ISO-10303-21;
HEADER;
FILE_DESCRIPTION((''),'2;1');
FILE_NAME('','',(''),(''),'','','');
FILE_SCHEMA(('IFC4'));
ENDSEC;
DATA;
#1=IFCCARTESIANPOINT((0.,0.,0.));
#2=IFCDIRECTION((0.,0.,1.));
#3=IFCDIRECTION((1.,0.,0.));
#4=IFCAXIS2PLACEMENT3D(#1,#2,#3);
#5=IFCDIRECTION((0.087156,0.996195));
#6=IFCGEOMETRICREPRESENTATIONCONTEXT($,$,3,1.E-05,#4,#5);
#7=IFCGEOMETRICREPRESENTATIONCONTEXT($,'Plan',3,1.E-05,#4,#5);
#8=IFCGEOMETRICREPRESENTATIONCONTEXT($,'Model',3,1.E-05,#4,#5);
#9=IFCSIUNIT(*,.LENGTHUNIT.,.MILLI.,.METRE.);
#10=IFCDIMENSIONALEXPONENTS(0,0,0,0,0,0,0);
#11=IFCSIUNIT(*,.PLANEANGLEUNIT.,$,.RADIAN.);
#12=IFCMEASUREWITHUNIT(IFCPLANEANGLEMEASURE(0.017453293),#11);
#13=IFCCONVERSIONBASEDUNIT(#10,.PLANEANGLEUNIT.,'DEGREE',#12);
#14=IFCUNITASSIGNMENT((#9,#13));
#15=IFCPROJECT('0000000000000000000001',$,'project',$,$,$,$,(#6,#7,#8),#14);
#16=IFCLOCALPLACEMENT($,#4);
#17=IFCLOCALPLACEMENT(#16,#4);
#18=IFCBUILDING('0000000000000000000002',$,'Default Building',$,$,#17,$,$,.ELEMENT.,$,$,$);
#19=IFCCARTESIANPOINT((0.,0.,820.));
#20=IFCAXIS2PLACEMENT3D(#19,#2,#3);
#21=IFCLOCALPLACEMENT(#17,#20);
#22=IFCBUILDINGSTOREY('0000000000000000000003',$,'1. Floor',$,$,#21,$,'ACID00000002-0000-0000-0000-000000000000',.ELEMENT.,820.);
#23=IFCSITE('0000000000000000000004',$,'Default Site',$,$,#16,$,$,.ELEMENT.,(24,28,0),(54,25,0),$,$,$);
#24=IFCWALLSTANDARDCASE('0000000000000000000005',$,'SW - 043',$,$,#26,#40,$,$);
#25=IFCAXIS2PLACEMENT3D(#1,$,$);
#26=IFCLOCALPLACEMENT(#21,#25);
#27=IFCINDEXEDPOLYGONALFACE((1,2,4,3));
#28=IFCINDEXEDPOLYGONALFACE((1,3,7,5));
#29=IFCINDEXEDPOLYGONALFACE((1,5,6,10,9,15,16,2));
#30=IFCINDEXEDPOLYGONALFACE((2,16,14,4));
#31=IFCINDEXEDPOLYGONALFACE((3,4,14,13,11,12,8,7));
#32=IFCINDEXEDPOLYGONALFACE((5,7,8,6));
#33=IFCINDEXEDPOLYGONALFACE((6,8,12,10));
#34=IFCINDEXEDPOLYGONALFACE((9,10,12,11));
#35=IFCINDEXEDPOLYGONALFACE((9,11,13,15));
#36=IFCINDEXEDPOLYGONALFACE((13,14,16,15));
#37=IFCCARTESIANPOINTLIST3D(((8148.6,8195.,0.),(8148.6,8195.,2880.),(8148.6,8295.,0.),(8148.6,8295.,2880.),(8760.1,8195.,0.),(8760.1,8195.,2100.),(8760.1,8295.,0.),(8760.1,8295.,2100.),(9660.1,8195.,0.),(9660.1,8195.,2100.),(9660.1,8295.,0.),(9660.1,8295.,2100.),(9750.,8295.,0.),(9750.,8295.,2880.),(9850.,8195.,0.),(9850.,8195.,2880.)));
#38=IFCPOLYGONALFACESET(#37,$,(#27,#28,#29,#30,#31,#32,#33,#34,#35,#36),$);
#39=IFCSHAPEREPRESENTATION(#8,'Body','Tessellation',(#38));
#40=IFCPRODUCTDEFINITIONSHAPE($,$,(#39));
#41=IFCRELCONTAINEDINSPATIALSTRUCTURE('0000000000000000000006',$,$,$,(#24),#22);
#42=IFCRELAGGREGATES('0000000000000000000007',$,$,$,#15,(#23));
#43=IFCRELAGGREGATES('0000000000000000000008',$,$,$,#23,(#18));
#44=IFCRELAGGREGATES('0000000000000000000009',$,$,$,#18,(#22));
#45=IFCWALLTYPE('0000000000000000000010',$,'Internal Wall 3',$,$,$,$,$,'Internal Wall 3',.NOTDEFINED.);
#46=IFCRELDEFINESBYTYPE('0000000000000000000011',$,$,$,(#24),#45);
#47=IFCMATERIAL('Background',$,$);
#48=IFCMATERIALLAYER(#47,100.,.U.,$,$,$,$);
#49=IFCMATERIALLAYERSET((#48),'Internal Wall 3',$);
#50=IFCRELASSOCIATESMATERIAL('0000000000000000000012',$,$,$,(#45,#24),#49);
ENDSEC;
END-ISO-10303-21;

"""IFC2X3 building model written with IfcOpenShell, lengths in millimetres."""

from ifc_helpers import new_model, entity, si_unit, converted_unit, direction, frame, frame_2d, origin_with_axes, place, context, project, spatial, polyline, rectangle, outline, extrude, material, layer, layer_set, layer_usage, type_object, element, save


model = new_model("IFC2X3")

# Units and contexts
context_of_model = context(None, 3, precision=1e-05, world=origin_with_axes(), true_north=direction((0.087156, 0.996195)))
plan_context = context("Plan", 3, precision=1e-05, world=origin_with_axes(), true_north=direction((0.087156, 0.996195)))
model_context = context("Model", 3, precision=1e-05, world=origin_with_axes(), true_north=direction((0.087156, 0.996195)))
ifc_project = project(units=[si_unit("LENGTHUNIT", "METRE", prefix="MILLI"), converted_unit("PLANEANGLEUNIT", "DEGREE", entity("IfcPlaneAngleMeasure", 0.017453293), si_unit("PLANEANGLEUNIT", "RADIAN"), dimensions=[0, 0, 0, 0, 0, 0, 0])], contexts=[context_of_model, plan_context, model_context])

# Site, building, storey
site_placement = place(None, origin_with_axes())
site = spatial("IfcSite", under=ifc_project, at=site_placement, Name="Default Site", CompositionType="ELEMENT", RefLatitude=(24, 28, 0), RefLongitude=(54, 25, 0))
building_placement = place(site_placement, origin_with_axes())
building = spatial("IfcBuilding", under=site, at=building_placement, Name="Default Building", CompositionType="ELEMENT")
storey_placement = place(building_placement, frame((0.0, 0.0, 820.0), z_axis=(0.0, 0.0, 1.0), x_axis=(1.0, 0.0, 0.0)))
storey = spatial("IfcBuildingStorey", under=building, at=storey_placement, Name="1. Floor", LongName="ACID00000002-0000-0000-0000-000000000000", CompositionType="ELEMENT", Elevation=820.0)

# Shared definitions
ifc_material_1 = material(Name="Background")

# Wall, opening
ifc_layer_1 = layer(ifc_material_1, 100.0, ventilated="UNKNOWN")
ifc_layer_set_1 = layer_set([ifc_layer_1], Name="Internal Wall 3")
ifc_layer_usage_1 = layer_usage(ifc_layer_set_1, "AXIS2", "NEGATIVE", 0.0)
wall_type_1 = type_object("IfcWallType", Name="Internal Wall 3", ElementType="Internal Wall 3", PredefinedType="NOTDEFINED", material=ifc_layer_set_1)
wall_1_placement = place(storey_placement, frame((9850.0, 8195.0, 0.0), z_axis=(0.0, 0.0, 1.0), x_axis=(-1.0, 0.0, 0.0)))
wall_1 = element("IfcWallStandardCase", 1, at=wall_1_placement, inside=storey, type_object=wall_type_1, material=ifc_layer_usage_1, Name="SW - 043", context=model_context, shape_type="SweptSolid", body=[
    extrude(outline(polyline([(100.0, -100.0), (1701.4, -100.0), (1701.4, 0.0), (0.0, 0.0), (100.0, -100.0)])), origin_with_axes(), (0.0, 0.0, 1.0), 2880.0),
])
opening_1_placement = place(wall_1_placement, frame((639.9, -100.0, 0.0), z_axis=(0.0, 0.0, 1.0), x_axis=(1.0, 0.0, 0.0)))
element("IfcOpeningElement", 2, at=opening_1_placement, cuts=wall_1, ObjectType="Opening", context=model_context, shape_type="SweptSolid", body=[
    extrude(rectangle(XDim=900.0, YDim=2100.0, at=frame_2d((0.0, 1050.0), x_axis=(-1.0, 0.0))), frame((0.0, 0.0, 0.0), z_axis=(0.0, 1.0, 0.0), x_axis=(-1.0, 0.0, 0.0)), (0.0, 0.0, 1.0), 100.0),
])

save(model, "model.ifc")
